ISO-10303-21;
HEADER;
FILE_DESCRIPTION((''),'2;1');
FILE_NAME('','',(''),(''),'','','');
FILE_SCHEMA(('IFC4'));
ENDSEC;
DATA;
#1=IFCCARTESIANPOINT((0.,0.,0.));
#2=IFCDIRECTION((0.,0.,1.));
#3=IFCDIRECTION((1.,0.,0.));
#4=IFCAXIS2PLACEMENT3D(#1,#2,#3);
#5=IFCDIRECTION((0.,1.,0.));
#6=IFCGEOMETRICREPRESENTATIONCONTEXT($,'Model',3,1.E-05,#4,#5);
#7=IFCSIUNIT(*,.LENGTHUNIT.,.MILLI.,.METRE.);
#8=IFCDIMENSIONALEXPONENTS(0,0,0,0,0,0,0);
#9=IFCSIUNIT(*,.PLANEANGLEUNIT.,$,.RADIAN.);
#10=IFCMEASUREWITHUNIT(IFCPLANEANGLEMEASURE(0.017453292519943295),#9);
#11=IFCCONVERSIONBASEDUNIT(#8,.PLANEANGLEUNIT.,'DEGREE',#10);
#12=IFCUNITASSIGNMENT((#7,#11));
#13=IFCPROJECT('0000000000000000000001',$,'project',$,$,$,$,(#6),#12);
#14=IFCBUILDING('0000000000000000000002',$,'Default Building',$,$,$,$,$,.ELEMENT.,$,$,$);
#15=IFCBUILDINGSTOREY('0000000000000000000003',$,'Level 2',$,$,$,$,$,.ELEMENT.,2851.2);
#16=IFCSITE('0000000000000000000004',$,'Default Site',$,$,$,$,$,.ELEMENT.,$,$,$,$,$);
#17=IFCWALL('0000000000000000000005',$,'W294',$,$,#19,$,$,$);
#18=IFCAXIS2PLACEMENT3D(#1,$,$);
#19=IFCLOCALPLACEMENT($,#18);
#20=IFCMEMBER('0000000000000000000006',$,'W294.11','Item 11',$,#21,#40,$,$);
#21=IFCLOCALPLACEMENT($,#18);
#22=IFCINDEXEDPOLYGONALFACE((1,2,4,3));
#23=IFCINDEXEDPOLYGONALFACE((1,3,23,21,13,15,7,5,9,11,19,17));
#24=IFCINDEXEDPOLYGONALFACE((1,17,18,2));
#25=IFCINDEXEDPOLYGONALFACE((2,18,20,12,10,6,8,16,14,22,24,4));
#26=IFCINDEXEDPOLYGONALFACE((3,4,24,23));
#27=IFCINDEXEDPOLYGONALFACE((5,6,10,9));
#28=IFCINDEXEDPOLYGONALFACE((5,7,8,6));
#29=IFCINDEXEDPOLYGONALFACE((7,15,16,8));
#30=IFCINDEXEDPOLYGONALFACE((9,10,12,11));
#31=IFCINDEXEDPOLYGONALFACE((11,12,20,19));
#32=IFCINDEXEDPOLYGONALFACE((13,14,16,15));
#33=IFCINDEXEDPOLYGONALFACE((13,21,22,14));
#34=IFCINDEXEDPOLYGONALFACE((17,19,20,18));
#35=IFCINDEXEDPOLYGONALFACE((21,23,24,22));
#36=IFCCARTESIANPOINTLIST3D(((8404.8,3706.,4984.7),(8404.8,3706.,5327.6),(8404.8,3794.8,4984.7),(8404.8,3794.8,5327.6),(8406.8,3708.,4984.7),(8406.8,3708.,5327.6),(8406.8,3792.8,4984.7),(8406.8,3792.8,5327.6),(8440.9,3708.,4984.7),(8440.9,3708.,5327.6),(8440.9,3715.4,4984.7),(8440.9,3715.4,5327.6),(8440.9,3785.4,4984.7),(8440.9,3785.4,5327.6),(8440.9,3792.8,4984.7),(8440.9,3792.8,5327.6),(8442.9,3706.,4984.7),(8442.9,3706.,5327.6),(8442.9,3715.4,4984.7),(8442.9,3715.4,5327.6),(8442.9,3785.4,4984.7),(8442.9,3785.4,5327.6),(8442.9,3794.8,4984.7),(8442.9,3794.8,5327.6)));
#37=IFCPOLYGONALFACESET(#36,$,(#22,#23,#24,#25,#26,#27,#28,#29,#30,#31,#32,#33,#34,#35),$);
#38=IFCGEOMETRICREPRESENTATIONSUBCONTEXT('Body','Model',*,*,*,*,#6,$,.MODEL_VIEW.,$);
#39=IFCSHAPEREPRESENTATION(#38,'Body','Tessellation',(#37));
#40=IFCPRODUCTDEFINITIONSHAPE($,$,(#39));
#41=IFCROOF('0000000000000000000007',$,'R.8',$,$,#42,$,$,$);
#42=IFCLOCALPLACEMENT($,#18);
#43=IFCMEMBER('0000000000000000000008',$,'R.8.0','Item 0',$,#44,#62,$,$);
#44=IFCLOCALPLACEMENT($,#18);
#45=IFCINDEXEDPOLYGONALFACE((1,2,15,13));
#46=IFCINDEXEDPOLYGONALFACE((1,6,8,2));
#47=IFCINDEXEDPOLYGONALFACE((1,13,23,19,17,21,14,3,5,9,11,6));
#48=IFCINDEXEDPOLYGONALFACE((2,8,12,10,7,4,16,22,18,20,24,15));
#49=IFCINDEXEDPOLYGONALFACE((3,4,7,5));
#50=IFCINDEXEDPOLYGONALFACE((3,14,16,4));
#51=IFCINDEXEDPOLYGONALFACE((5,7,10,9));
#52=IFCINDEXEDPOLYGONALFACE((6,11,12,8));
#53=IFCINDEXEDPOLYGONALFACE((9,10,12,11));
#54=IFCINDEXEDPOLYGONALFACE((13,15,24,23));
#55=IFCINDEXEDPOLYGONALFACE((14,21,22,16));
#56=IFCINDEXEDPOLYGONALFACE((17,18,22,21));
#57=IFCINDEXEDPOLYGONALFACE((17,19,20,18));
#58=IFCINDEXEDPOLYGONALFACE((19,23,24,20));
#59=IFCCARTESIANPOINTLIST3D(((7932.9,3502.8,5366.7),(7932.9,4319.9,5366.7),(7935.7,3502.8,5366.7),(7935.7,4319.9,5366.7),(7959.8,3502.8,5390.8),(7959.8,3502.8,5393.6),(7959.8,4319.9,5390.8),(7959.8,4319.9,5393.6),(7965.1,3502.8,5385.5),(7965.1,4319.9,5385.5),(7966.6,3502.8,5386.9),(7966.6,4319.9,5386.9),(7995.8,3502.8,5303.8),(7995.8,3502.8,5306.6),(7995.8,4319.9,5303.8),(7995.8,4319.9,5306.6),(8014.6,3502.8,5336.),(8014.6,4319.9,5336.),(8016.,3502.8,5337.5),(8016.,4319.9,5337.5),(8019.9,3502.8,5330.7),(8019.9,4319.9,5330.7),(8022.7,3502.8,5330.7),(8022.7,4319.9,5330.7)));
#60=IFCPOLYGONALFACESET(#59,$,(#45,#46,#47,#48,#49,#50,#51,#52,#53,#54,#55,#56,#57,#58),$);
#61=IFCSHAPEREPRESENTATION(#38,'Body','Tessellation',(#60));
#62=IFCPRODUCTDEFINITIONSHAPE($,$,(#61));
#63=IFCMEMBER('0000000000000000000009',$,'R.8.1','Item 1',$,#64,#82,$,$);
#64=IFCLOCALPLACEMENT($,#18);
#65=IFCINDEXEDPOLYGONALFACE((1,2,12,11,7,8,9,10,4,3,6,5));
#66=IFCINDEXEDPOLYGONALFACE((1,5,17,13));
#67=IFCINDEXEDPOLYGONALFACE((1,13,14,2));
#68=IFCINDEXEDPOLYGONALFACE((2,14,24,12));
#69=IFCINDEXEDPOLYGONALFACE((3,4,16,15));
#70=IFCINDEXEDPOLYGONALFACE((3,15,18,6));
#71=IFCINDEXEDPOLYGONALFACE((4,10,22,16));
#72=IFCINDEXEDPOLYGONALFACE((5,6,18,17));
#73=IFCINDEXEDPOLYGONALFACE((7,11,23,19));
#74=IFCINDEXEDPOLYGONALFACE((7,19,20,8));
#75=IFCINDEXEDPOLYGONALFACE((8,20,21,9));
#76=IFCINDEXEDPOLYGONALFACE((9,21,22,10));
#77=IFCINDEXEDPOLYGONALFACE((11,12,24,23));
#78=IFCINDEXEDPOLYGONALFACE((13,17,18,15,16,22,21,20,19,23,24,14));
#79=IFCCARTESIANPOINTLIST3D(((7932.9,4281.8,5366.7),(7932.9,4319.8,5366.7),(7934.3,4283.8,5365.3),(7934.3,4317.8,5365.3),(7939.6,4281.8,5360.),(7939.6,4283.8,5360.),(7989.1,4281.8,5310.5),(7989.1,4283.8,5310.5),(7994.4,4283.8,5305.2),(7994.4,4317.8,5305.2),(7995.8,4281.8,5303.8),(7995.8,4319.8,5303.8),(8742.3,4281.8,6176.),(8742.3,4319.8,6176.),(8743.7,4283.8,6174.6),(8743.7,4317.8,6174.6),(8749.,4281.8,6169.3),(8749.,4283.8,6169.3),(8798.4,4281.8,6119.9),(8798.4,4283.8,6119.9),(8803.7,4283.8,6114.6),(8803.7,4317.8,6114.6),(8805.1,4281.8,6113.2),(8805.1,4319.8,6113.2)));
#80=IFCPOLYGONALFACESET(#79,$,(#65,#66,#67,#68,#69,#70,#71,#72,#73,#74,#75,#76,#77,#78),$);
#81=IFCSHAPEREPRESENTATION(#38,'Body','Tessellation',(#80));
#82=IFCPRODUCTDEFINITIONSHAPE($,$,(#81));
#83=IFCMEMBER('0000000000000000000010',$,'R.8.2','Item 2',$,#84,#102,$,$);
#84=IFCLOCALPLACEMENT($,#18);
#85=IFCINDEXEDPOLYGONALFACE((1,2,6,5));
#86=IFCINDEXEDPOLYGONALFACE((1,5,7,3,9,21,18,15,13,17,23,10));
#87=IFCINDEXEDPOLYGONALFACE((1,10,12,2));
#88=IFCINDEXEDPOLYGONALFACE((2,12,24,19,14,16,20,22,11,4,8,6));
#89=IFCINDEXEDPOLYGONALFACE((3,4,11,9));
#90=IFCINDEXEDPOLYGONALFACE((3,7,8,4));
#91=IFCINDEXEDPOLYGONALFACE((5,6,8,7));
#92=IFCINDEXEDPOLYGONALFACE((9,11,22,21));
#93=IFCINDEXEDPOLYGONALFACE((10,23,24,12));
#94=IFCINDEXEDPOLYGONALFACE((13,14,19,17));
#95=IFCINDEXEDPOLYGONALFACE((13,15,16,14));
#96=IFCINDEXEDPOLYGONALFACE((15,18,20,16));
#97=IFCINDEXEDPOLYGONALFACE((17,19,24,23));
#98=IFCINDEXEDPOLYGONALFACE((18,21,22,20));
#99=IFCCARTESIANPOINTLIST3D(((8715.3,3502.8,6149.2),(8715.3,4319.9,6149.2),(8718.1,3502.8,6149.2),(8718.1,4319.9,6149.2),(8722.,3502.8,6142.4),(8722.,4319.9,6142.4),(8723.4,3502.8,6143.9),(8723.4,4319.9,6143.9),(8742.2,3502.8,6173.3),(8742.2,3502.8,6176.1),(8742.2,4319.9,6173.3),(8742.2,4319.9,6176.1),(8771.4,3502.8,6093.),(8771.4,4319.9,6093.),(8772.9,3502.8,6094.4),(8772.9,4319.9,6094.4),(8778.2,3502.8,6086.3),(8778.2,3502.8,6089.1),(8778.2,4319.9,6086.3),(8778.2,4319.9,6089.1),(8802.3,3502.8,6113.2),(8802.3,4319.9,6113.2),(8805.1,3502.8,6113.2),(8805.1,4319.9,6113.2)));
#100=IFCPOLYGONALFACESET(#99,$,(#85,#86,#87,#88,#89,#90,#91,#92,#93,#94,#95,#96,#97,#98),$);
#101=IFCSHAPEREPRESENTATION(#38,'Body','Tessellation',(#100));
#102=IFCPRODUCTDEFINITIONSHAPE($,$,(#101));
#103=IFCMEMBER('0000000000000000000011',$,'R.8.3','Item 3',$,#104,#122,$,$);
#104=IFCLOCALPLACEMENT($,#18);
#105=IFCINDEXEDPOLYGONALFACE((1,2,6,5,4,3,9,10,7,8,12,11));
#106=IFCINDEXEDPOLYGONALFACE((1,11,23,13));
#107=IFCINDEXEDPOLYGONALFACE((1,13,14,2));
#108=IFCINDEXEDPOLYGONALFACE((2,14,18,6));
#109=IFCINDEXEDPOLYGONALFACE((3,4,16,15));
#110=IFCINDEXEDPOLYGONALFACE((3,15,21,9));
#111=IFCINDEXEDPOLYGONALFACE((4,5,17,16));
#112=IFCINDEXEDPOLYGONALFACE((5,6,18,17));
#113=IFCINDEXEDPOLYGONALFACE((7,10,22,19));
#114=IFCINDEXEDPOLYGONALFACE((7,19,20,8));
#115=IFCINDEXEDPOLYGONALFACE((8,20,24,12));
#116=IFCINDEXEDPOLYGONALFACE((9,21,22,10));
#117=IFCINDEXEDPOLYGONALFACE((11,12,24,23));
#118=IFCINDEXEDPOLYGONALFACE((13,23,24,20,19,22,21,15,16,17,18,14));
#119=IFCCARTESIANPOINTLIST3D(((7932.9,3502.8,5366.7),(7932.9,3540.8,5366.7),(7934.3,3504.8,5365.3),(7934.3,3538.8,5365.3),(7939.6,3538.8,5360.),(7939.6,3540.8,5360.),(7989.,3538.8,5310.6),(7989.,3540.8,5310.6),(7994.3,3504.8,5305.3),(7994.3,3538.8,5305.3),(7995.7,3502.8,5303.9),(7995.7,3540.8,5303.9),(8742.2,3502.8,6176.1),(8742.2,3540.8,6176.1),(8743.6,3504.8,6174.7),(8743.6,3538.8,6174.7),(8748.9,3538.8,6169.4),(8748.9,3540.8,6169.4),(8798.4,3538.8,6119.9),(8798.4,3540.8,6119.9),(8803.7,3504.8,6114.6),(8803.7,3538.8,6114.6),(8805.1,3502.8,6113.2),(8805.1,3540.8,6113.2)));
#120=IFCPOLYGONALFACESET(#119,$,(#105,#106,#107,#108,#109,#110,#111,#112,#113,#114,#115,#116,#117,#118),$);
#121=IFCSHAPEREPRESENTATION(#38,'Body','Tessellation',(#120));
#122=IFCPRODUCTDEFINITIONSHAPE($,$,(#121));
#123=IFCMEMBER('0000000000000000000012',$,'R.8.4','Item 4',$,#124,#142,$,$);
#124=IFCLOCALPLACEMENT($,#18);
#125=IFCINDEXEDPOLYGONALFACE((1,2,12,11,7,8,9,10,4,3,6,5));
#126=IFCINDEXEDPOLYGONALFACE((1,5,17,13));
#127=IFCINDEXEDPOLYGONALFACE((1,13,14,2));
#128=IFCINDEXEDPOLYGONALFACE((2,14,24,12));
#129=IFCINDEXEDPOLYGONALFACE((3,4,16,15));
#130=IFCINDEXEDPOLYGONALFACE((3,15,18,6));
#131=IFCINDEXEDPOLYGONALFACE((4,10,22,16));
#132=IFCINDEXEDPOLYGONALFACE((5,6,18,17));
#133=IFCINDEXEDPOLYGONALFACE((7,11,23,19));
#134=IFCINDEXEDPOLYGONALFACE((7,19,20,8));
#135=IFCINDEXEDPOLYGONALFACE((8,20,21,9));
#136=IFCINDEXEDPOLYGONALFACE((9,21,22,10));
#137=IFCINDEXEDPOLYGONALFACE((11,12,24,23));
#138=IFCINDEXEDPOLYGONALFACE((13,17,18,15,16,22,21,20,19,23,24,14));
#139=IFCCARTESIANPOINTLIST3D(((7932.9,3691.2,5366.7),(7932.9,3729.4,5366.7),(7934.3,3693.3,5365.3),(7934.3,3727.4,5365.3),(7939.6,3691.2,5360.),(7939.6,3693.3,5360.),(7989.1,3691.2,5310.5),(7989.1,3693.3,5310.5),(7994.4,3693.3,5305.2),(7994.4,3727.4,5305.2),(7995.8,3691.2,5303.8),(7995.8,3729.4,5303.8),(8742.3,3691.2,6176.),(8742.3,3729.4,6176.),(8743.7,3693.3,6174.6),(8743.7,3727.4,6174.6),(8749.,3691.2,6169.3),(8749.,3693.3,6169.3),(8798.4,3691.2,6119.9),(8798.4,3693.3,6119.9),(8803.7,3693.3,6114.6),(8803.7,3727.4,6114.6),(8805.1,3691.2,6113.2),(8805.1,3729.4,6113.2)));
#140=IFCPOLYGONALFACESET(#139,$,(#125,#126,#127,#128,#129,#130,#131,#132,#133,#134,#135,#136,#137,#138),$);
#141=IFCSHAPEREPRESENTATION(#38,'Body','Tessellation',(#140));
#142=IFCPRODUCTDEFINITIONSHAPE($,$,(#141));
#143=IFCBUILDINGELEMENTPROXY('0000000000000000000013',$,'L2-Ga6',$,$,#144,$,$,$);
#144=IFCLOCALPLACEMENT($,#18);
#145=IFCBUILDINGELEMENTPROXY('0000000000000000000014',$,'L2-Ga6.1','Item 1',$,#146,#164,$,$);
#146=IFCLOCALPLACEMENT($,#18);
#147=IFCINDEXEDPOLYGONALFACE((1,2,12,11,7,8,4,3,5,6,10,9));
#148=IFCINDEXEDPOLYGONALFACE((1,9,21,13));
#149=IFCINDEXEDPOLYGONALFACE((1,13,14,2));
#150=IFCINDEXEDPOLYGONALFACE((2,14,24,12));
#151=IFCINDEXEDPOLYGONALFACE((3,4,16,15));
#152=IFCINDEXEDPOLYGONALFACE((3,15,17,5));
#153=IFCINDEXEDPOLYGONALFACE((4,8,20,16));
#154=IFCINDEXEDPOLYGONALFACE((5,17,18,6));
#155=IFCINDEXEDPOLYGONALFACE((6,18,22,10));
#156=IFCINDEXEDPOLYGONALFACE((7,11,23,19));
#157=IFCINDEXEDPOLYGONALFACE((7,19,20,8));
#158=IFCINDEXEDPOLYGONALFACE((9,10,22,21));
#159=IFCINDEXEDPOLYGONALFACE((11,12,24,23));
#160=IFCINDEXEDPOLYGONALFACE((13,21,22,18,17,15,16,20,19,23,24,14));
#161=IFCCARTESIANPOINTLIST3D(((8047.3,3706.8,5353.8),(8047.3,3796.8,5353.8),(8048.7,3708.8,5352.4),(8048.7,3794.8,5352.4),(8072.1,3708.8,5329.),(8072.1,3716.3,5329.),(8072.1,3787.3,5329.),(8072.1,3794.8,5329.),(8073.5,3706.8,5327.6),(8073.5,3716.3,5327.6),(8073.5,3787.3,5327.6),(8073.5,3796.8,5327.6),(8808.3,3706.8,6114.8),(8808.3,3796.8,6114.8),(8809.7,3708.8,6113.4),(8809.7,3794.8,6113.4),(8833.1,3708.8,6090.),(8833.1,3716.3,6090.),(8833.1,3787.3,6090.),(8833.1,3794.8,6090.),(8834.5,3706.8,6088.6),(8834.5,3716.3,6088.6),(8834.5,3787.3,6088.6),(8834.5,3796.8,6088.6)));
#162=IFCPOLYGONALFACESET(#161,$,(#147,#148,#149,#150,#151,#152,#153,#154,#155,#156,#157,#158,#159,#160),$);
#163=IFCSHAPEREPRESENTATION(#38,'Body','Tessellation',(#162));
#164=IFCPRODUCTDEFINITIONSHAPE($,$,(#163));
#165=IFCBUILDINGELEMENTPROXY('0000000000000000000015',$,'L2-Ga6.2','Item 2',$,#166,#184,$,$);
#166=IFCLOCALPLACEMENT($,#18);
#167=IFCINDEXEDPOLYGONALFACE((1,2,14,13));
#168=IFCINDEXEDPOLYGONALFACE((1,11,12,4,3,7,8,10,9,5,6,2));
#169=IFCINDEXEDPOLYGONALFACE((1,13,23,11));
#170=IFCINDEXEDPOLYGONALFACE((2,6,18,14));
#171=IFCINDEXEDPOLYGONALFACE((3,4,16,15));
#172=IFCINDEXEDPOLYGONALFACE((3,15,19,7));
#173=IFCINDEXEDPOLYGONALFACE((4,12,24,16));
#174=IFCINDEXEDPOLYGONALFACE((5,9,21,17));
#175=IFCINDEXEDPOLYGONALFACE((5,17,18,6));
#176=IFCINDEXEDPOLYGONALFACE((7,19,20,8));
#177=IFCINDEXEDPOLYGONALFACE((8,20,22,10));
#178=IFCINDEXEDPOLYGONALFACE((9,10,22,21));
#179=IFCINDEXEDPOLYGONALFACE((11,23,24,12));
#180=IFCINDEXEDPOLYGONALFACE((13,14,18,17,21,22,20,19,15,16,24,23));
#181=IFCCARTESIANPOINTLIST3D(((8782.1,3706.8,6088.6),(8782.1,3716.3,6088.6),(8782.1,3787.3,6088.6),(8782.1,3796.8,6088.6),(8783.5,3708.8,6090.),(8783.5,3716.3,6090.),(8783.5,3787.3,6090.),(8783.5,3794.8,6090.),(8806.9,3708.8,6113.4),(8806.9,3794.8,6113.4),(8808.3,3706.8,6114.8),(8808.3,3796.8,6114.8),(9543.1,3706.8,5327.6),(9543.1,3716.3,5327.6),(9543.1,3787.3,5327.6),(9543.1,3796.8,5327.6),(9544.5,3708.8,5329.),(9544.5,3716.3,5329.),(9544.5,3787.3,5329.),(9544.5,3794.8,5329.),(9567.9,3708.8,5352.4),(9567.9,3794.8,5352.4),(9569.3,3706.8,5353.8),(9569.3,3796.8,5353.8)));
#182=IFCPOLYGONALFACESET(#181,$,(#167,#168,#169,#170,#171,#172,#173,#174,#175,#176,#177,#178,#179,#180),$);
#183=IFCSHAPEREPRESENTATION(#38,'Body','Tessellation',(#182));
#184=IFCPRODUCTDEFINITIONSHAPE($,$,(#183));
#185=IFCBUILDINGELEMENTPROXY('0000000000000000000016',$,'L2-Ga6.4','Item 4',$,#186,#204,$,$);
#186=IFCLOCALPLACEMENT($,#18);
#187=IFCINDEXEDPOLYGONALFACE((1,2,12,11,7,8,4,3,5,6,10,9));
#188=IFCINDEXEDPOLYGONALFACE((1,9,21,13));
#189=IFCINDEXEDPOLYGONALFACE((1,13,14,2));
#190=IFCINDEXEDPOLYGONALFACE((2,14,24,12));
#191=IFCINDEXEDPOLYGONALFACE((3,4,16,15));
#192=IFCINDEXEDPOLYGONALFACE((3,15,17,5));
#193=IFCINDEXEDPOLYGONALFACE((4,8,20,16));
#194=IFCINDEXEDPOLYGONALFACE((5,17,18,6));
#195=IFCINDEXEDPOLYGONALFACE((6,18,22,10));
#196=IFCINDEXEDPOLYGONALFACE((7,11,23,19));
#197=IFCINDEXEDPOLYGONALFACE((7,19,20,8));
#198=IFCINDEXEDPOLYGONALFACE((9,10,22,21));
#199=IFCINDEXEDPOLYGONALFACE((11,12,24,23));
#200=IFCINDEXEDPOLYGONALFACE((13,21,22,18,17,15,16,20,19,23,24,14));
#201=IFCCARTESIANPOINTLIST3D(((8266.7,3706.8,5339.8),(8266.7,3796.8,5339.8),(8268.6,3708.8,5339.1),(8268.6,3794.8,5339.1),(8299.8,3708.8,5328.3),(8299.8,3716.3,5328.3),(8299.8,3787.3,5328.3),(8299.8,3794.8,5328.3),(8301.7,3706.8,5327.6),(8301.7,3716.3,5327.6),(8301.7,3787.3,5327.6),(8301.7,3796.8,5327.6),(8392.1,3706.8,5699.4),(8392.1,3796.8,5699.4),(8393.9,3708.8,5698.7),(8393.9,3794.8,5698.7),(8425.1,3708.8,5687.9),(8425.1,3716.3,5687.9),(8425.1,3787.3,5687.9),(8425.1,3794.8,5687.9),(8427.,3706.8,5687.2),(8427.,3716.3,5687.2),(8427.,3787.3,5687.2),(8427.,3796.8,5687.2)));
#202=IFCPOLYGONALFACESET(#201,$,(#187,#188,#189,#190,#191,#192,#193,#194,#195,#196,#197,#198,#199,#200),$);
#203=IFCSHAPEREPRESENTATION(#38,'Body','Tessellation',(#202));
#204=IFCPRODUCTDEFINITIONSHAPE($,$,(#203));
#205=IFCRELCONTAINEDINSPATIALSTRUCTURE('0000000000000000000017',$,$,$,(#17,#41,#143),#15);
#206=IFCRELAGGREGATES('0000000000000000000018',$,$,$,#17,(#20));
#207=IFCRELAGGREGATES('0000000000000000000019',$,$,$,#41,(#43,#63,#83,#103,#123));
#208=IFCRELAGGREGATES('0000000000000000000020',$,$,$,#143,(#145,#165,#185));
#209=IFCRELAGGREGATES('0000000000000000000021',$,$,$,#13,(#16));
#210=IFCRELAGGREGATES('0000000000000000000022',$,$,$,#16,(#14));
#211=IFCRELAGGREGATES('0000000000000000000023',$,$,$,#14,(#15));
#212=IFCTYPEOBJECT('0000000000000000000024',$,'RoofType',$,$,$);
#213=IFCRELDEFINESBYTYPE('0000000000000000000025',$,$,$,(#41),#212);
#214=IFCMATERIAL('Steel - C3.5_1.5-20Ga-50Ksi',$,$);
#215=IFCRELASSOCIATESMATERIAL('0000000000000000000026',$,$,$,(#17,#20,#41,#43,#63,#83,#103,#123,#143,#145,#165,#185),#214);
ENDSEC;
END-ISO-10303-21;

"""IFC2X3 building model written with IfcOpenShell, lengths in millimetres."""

from ifc_helpers import new_model, entity, si_unit, converted_unit, direction, frame, origin, origin_with_axes, origin_2d_with_axis, place, context, subcontext, project, spatial, c_section, extrude, material, type_object, element, aggregate, save


model = new_model("IFC2X3")

# Units and contexts
model_context = context("Model", 3, precision=1e-05, world=origin_with_axes(), true_north=direction((0.0, 1.0, 0.0)))
body_context = subcontext(model_context, "Body", "Model", "MODEL_VIEW")
ifc_project = project(units=[si_unit("LENGTHUNIT", "METRE", prefix="MILLI"), converted_unit("PLANEANGLEUNIT", "DEGREE", entity("IfcPlaneAngleMeasure", 0.017453292519943295), si_unit("PLANEANGLEUNIT", "RADIAN"), dimensions=[0, 0, 0, 0, 0, 0, 0])], contexts=[model_context])

# Site, building, storey
site = spatial("IfcSite", under=ifc_project, Name="Default Site", CompositionType="ELEMENT")
building = spatial("IfcBuilding", under=site, Name="Default Building", CompositionType="ELEMENT")
storey = spatial("IfcBuildingStorey", under=building, Name="Level 2", CompositionType="ELEMENT", Elevation=2851.2)

# Wall, member
ifc_material_1 = material(Name="Steel - C3.5_1.5-20Ga-50Ksi")
wall = element("IfcWall", 1, inside=storey, material=ifc_material_1, Name="W294")
member_1_placement = place(None, frame((8423.9, 3750.4, 5327.6), z_axis=(0.0, 0.0, -1.0), x_axis=(1.0, 0.0, 0.0)))
member_1 = element("IfcMember", 2, at=member_1_placement, material=ifc_material_1, Name="W294.11", Description="Item 11", context=body_context, shape_type="SweptSolid", body=[
    extrude(c_section(Depth=88.9, Width=38.1, WallThickness=2.0, Girth=9.5, at=origin_2d_with_axis()), origin(), (0.0, 0.0, 1.0), 342.9),
])
aggregate(wall, [member_1])

# Roof, members
ifc_type_object = type_object("IfcTypeObject", Name="RoofType")
roof = element("IfcRoof", 3, inside=storey, type_object=ifc_type_object, material=ifc_material_1, Name="R.8")
member_2_placement = place(None, frame((7977.8, 4319.9, 5348.7), z_axis=(0.0, -1.0, 0.0), x_axis=(0.707, 0.0, 0.707)))
member_2 = element("IfcMember", 4, at=member_2_placement, material=ifc_material_1, Name="R.8.0", Description="Item 0", context=body_context, shape_type="SweptSolid", body=[
    extrude(c_section(Depth=88.9, Width=38.1, WallThickness=2.0, Girth=9.5, at=origin_2d_with_axis()), origin(), (0.0, 0.0, 1.0), 817.1),
])
member_3_placement = place(None, frame((8773.7, 4300.8, 6144.6), z_axis=(-0.707, 0.0, -0.707), x_axis=(0.0, -1.0, 0.0)))
member_3 = element("IfcMember", 5, at=member_3_placement, material=ifc_material_1, Name="R.8.1", Description="Item 1", context=body_context, shape_type="SweptSolid", body=[
    extrude(c_section(Depth=88.9, Width=38.1, WallThickness=2.0, Girth=9.5, at=origin_2d_with_axis()), origin(), (0.0, 0.0, 1.0), 1144.6),
])
member_4_placement = place(None, frame((8760.2, 3502.8, 6131.2), z_axis=(0.0, 1.0, 0.0), x_axis=(-0.707, 0.0, -0.707)))
member_4 = element("IfcMember", 6, at=member_4_placement, material=ifc_material_1, Name="R.8.2", Description="Item 2", context=body_context, shape_type="SweptSolid", body=[
    extrude(c_section(Depth=88.9, Width=38.1, WallThickness=2.0, Girth=9.5, at=origin_2d_with_axis()), origin(), (0.0, 0.0, 1.0), 817.1),
])
member_5_placement = place(None, frame((7964.3, 3521.8, 5335.3), z_axis=(0.707, 0.0, 0.707), x_axis=(0.0, 1.0, 0.0)))
member_5 = element("IfcMember", 7, at=member_5_placement, material=ifc_material_1, Name="R.8.3", Description="Item 3", context=body_context, shape_type="SweptSolid", body=[
    extrude(c_section(Depth=88.9, Width=38.1, WallThickness=2.0, Girth=9.5, at=origin_2d_with_axis()), origin(), (0.0, 0.0, 1.0), 1144.6),
])
member_6_placement = place(None, frame((8773.7, 3710.3, 6144.6), z_axis=(-0.707, 0.0, -0.707), x_axis=(0.0, -1.0, 0.0)))
member_6 = element("IfcMember", 8, at=member_6_placement, material=ifc_material_1, Name="R.8.4", Description="Item 4", context=body_context, shape_type="SweptSolid", body=[
    extrude(c_section(Depth=88.9, Width=38.1, WallThickness=2.0, Girth=9.5, at=origin_2d_with_axis()), origin(), (0.0, 0.0, 1.0), 1144.6),
])
aggregate(roof, [member_2, member_3, member_4, member_5, member_6])

# Building element proxies
proxy_1 = element("IfcBuildingElementProxy", 9, inside=storey, material=ifc_material_1, Name="L2-Ga6")
proxy_2_placement = place(None, frame((8060.4, 3751.8, 5340.7), z_axis=(0.707, 0.0, 0.707), x_axis=(26.163, 0.0, -26.163)))
proxy_2 = element("IfcBuildingElementProxy", 10, at=proxy_2_placement, material=ifc_material_1, Name="L2-Ga6.1", Description="Item 1", context=body_context, shape_type="SweptSolid", body=[
    extrude(c_section(Depth=90.0, Width=37.0, WallThickness=2.0, Girth=9.5, at=origin_2d_with_axis()), origin(), (0.0, 0.0, 1.0), 1076.2),
])
proxy_3_placement = place(None, frame((8795.2, 3751.8, 6101.7), z_axis=(0.707, 0.0, -0.707), x_axis=(-26.163, 0.0, -26.163)))
proxy_3 = element("IfcBuildingElementProxy", 11, at=proxy_3_placement, material=ifc_material_1, Name="L2-Ga6.2", Description="Item 2", context=body_context, shape_type="SweptSolid", body=[
    extrude(c_section(Depth=90.0, Width=37.0, WallThickness=2.0, Girth=9.5, at=origin_2d_with_axis()), origin(), (0.0, 0.0, 1.0), 1076.2),
])
proxy_4_placement = place(None, frame((8284.2, 3751.8, 5333.7), z_axis=(0.329, 0.0, 0.944), x_axis=(34.944, 0.0, -12.162)))
proxy_4 = element("IfcBuildingElementProxy", 12, at=proxy_4_placement, material=ifc_material_1, Name="L2-Ga6.4", Description="Item 4", context=body_context, shape_type="SweptSolid", body=[
    extrude(c_section(Depth=90.0, Width=37.0, WallThickness=2.0, Girth=9.5, at=origin_2d_with_axis()), origin(), (0.0, 0.0, 1.0), 380.8),
])
aggregate(proxy_1, [proxy_2, proxy_3, proxy_4])

save(model, "model.ifc")
